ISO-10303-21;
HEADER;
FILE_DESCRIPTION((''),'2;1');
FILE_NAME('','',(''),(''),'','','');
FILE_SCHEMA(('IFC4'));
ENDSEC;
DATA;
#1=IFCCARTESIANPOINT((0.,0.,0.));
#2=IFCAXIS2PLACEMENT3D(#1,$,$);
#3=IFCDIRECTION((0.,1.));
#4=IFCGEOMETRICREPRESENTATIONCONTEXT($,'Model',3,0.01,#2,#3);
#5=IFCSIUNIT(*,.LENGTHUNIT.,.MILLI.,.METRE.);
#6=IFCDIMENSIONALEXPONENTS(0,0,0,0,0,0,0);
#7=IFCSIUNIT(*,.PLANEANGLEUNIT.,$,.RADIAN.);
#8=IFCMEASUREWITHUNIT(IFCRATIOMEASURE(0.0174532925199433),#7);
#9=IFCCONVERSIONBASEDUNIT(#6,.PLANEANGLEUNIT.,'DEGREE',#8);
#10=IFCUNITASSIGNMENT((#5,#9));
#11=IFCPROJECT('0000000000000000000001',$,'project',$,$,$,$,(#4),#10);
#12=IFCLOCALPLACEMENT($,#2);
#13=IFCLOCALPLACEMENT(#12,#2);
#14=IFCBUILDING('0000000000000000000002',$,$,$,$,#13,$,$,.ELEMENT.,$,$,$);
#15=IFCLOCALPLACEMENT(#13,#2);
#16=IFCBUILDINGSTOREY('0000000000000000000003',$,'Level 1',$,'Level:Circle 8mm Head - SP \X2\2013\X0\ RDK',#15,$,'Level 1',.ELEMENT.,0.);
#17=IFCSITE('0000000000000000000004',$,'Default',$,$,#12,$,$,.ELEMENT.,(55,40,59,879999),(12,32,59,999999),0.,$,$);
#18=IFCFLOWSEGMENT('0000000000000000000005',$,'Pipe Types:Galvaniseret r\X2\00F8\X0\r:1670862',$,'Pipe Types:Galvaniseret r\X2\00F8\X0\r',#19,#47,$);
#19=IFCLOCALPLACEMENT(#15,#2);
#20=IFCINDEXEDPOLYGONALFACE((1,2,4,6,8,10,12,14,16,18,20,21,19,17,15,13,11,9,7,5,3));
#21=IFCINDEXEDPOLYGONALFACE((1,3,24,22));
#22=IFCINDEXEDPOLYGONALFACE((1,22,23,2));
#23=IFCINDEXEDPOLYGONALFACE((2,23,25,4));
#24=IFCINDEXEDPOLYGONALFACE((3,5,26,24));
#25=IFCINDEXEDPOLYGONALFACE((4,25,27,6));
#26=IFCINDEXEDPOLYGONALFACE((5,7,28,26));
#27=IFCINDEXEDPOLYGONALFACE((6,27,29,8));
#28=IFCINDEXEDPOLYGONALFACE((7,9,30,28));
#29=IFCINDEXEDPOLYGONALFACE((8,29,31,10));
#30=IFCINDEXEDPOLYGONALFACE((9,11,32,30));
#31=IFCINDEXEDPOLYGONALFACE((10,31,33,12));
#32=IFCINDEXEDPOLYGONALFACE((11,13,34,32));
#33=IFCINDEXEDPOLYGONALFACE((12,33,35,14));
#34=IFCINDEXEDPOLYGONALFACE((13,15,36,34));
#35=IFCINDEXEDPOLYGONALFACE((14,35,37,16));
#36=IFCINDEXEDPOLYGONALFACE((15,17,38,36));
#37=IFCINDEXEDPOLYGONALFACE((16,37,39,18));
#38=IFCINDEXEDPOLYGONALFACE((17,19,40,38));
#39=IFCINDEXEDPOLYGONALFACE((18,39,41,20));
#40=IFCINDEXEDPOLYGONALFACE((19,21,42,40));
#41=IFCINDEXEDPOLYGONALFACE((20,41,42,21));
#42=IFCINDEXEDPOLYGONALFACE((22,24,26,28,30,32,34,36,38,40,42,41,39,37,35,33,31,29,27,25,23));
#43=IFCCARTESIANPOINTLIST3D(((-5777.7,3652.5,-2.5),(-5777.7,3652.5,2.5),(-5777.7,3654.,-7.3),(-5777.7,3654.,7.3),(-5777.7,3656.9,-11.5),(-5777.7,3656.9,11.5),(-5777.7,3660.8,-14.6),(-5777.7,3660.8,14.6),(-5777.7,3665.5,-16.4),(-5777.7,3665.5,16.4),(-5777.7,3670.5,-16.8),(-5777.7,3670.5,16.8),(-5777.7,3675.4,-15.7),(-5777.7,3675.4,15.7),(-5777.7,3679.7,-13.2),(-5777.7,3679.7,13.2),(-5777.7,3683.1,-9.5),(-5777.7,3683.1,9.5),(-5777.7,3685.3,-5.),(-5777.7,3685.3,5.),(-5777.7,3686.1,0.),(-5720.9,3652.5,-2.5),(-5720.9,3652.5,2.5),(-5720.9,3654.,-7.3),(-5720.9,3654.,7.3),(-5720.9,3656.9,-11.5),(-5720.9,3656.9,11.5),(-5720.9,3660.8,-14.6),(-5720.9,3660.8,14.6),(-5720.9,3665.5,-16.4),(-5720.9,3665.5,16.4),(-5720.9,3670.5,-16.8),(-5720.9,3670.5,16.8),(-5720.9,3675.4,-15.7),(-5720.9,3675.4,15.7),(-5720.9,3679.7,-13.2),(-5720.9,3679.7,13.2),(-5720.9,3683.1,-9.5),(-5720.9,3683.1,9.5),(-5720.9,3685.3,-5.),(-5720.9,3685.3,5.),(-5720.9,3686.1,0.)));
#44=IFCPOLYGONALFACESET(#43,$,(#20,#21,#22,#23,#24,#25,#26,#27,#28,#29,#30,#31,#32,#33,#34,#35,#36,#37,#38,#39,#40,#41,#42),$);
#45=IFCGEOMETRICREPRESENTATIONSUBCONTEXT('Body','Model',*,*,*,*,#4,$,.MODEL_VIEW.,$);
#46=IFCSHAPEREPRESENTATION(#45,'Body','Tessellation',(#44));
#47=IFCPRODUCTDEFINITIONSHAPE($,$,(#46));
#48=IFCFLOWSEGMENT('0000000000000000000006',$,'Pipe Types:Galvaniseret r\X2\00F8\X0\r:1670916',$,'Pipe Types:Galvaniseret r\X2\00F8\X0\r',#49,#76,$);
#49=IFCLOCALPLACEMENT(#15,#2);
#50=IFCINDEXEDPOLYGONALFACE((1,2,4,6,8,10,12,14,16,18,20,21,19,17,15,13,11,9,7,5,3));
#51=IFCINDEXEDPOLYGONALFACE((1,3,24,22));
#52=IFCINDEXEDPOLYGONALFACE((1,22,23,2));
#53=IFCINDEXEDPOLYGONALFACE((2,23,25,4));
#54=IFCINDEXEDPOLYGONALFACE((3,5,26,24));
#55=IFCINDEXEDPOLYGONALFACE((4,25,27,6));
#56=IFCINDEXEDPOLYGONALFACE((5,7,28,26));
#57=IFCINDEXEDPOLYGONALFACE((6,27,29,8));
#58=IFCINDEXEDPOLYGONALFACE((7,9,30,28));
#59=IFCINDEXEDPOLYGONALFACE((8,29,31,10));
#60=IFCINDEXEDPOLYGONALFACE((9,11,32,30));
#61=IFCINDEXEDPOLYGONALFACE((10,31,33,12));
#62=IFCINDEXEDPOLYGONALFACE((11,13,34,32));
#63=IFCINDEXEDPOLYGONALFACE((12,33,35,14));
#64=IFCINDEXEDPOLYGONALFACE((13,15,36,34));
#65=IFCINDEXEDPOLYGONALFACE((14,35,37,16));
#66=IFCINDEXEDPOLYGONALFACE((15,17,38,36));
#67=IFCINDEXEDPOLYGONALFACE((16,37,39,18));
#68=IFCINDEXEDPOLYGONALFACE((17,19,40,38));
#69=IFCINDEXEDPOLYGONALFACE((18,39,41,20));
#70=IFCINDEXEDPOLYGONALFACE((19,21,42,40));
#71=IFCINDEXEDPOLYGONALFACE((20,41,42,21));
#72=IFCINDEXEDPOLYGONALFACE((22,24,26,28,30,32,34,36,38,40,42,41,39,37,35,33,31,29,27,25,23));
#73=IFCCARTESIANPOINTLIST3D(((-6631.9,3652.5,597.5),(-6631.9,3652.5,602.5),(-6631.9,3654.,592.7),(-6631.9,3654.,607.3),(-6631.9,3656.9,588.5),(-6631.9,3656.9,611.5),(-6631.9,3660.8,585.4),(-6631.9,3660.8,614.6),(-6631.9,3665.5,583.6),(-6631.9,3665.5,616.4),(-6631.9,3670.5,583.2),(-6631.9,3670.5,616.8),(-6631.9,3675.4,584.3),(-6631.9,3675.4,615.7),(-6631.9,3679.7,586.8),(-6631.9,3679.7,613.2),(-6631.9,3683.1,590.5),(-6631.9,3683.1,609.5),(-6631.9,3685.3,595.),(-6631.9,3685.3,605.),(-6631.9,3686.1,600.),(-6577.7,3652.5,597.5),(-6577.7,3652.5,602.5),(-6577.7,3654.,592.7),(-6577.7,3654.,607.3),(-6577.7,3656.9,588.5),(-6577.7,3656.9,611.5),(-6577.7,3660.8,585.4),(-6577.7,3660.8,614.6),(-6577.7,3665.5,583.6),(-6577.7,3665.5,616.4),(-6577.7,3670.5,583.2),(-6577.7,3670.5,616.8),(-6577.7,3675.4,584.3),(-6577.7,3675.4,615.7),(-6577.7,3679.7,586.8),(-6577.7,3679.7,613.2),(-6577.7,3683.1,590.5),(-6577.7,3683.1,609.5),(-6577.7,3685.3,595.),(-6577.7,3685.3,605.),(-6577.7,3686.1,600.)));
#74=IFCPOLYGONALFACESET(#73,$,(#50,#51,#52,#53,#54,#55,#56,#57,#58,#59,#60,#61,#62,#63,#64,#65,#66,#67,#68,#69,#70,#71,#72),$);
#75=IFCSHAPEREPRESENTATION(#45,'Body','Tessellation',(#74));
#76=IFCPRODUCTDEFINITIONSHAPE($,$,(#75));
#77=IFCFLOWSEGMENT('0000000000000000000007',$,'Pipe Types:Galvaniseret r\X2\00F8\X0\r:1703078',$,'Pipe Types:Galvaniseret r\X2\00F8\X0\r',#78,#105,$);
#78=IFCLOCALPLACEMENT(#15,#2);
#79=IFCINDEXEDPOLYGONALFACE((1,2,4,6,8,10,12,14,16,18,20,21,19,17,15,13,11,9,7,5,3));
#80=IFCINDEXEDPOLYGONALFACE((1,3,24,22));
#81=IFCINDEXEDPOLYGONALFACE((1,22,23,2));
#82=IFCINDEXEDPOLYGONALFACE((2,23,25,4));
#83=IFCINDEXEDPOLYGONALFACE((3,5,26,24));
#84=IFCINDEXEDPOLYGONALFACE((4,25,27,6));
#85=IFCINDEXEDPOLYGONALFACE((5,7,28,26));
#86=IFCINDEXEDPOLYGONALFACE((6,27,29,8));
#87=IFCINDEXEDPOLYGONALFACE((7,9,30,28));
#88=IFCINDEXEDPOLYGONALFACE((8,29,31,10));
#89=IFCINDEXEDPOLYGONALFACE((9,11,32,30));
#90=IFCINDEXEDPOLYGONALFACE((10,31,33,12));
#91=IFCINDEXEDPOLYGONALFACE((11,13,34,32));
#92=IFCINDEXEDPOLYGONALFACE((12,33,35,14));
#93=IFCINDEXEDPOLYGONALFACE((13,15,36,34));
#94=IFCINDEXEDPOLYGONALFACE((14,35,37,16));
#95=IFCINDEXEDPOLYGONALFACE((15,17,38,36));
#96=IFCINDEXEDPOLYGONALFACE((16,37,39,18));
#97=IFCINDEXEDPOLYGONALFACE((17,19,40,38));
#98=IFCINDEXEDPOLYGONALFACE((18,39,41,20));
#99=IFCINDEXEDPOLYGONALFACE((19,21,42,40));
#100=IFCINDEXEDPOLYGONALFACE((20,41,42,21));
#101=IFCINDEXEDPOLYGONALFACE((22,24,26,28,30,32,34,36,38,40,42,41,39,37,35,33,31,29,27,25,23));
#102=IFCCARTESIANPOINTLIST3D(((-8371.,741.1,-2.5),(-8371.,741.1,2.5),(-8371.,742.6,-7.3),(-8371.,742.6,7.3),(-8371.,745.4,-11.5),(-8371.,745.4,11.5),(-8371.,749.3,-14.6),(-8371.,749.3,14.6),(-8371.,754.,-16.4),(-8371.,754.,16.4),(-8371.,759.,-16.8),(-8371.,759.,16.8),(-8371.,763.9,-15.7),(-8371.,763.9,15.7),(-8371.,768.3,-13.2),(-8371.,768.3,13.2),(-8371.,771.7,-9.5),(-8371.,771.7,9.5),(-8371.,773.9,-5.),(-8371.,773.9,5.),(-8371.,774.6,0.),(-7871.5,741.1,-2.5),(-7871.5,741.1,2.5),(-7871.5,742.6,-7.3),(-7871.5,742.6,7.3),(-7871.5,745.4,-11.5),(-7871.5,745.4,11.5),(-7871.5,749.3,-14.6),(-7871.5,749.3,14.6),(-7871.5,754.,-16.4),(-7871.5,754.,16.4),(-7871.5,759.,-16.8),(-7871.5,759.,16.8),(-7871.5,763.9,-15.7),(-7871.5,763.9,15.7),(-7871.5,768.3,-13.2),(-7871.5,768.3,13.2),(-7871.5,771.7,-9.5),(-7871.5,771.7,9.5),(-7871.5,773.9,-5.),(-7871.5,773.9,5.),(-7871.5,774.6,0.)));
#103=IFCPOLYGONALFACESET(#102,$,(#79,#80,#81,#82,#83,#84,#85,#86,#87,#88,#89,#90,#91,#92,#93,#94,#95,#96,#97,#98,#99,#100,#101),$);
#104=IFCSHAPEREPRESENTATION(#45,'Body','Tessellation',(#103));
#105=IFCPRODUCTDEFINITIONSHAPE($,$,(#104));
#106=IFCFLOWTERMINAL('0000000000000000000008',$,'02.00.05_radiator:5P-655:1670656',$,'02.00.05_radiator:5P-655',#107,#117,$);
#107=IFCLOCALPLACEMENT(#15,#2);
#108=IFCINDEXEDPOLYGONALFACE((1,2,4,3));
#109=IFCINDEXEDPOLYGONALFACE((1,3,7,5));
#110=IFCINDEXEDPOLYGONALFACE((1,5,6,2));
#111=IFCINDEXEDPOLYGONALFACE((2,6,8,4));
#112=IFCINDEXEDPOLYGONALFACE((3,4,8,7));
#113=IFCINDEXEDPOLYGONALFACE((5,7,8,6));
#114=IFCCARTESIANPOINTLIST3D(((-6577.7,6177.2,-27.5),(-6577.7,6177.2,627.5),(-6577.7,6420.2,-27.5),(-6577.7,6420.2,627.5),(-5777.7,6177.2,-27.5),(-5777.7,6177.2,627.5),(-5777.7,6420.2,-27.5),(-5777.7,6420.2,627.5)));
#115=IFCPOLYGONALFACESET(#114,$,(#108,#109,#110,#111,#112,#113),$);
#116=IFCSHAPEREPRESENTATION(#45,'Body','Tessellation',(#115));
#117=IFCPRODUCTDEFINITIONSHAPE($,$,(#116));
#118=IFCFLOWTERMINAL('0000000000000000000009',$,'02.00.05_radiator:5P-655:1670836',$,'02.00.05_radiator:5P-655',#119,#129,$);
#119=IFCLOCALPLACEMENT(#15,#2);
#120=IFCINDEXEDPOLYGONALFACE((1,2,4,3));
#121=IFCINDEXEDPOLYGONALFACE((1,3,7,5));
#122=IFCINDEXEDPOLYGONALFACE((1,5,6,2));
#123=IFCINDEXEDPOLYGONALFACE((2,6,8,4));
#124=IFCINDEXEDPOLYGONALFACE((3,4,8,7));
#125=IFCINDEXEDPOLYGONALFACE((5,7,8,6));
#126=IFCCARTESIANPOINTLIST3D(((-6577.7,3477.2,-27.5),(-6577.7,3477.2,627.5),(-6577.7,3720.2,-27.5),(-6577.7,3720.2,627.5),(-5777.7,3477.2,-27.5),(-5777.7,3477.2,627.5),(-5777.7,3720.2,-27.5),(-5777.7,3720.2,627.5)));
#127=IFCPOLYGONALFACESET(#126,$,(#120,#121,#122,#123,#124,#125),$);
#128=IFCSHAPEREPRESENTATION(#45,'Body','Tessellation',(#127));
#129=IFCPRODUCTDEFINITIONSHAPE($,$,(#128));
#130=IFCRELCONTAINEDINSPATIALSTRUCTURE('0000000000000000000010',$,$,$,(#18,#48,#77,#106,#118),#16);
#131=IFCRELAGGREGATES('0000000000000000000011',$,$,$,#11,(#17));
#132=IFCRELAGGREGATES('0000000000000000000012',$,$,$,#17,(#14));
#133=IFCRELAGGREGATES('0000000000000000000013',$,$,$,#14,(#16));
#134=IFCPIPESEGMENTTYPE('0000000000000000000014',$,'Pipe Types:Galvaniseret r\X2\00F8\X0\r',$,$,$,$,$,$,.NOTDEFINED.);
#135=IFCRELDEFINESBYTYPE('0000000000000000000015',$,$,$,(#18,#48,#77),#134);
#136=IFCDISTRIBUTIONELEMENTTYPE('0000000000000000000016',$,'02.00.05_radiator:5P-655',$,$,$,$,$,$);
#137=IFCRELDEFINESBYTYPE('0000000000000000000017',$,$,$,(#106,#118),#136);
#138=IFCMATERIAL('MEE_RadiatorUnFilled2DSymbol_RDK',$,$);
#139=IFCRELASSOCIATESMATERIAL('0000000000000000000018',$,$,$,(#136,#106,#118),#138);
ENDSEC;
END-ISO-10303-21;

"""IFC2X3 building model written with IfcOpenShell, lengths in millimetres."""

from ifc_helpers import new_model, entity, si_unit, converted_unit, direction, frame, frame_2d, origin, origin_2d_with_axis, place, context, subcontext, project, spatial, rectangle, circle, extrude, source, transform, mapped, material, type_object, type_shapes, element, save


model = new_model("IFC2X3")

# Units and contexts
model_context = context("Model", 3, precision=0.01, world=origin(), true_north=direction((0.0, 1.0)))
body_context = subcontext(model_context, "Body", "Model", "MODEL_VIEW")
ifc_project = project(units=[si_unit("LENGTHUNIT", "METRE", prefix="MILLI"), converted_unit("PLANEANGLEUNIT", "DEGREE", entity("IfcRatioMeasure", 0.0174532925199433), si_unit("PLANEANGLEUNIT", "RADIAN"), dimensions=[0, 0, 0, 0, 0, 0, 0])], contexts=[model_context])

# Site, building, storey
site_placement = place(None, origin())
site = spatial("IfcSite", under=ifc_project, at=site_placement, Name="Default", CompositionType="ELEMENT", RefLatitude=(55, 40, 59, 879999), RefLongitude=(12, 32, 59, 999999), RefElevation=0.0)
building_placement = place(site_placement, origin())
building = spatial("IfcBuilding", under=site, at=building_placement, CompositionType="ELEMENT")
storey_placement = place(building_placement, origin())
storey = spatial("IfcBuildingStorey", under=building, at=storey_placement, Name="Level 1", ObjectType="Level:Circle 8mm Head - SP – RDK", LongName="Level 1", CompositionType="ELEMENT", Elevation=0.0)

# Flow segments
pipe_segment_type = type_object("IfcPipeSegmentType", Name="Pipe Types:Galvaniseret rør", PredefinedType="NOTDEFINED")
flow_segment_1_placement = place(storey_placement, origin())
element("IfcFlowSegment", 1, at=flow_segment_1_placement, inside=storey, type_object=pipe_segment_type, Name="Pipe Types:Galvaniseret rør:1670862", ObjectType="Pipe Types:Galvaniseret rør", context=body_context, shape_type="SweptSolid", body=[
    extrude(circle(Radius=16.9, at=frame_2d((0.0, 0.0), x_axis=(1.0, 0.0))), frame((-5777.7, 3669.2, 0.0), z_axis=(1.0, 0.0, 0.0), x_axis=(0.0, 1.0, 0.0)), (0.0, 0.0, 1.0), 56.8),
])
flow_segment_2_placement = place(storey_placement, origin())
element("IfcFlowSegment", 2, at=flow_segment_2_placement, inside=storey, type_object=pipe_segment_type, Name="Pipe Types:Galvaniseret rør:1670916", ObjectType="Pipe Types:Galvaniseret rør", context=body_context, shape_type="SweptSolid", body=[
    extrude(circle(Radius=16.9, at=origin_2d_with_axis()), frame((-6631.9, 3669.2, 600.0), z_axis=(1.0, 0.0, 0.0), x_axis=(0.0, 1.0, 0.0)), (0.0, 0.0, 1.0), 54.2),
])
flow_segment_3_placement = place(storey_placement, origin())
element("IfcFlowSegment", 3, at=flow_segment_3_placement, inside=storey, type_object=pipe_segment_type, Name="Pipe Types:Galvaniseret rør:1703078", ObjectType="Pipe Types:Galvaniseret rør", context=body_context, shape_type="SweptSolid", body=[
    extrude(circle(Radius=16.9, at=frame_2d((0.0, 0.0), x_axis=(1.0, 0.0))), frame((-8371.0, 757.8, 0.0), z_axis=(1.0, 0.0, 0.0), x_axis=(0.0, 1.0, 0.0)), (0.0, 0.0, 1.0), 499.5),
])

# Flow terminals
ifc_material_1 = material(Name="MEE_RadiatorUnFilled2DSymbol_RDK")
distribution_element_type = type_object("IfcDistributionElementType", Name="02.00.05_radiator:5P-655", material=ifc_material_1)
shared_shape_1 = source(origin(), body_context, "Body", "SweptSolid", [
    extrude(rectangle(XDim=800.0, YDim=243.0, at=origin_2d_with_axis()), frame((0.0, -121.5, 0.0), z_axis=(0.0, 0.0, 1.0), x_axis=(-1.0, 0.0, 0.0)), (0.0, 0.0, 1.0), 655.0),
])
type_shapes(distribution_element_type, [shared_shape_1])
for number, where, name in (
    (4, (-6177.7, 6420.2, -27.5), "02.00.05_radiator:5P-655:1670656"),
    (5, (-6177.7, 3720.2, -27.5), "02.00.05_radiator:5P-655:1670836"),
):
    element("IfcFlowTerminal", number, at=place(storey_placement, frame(where)), inside=storey, type_object=distribution_element_type, material=ifc_material_1, Name=name, ObjectType="02.00.05_radiator:5P-655", context=body_context, shape_type="MappedRepresentation", body=[
        mapped(shared_shape_1, transform((0.0, 0.0, 0.0), scale=1.0)),
    ])

save(model, "model.ifc")
